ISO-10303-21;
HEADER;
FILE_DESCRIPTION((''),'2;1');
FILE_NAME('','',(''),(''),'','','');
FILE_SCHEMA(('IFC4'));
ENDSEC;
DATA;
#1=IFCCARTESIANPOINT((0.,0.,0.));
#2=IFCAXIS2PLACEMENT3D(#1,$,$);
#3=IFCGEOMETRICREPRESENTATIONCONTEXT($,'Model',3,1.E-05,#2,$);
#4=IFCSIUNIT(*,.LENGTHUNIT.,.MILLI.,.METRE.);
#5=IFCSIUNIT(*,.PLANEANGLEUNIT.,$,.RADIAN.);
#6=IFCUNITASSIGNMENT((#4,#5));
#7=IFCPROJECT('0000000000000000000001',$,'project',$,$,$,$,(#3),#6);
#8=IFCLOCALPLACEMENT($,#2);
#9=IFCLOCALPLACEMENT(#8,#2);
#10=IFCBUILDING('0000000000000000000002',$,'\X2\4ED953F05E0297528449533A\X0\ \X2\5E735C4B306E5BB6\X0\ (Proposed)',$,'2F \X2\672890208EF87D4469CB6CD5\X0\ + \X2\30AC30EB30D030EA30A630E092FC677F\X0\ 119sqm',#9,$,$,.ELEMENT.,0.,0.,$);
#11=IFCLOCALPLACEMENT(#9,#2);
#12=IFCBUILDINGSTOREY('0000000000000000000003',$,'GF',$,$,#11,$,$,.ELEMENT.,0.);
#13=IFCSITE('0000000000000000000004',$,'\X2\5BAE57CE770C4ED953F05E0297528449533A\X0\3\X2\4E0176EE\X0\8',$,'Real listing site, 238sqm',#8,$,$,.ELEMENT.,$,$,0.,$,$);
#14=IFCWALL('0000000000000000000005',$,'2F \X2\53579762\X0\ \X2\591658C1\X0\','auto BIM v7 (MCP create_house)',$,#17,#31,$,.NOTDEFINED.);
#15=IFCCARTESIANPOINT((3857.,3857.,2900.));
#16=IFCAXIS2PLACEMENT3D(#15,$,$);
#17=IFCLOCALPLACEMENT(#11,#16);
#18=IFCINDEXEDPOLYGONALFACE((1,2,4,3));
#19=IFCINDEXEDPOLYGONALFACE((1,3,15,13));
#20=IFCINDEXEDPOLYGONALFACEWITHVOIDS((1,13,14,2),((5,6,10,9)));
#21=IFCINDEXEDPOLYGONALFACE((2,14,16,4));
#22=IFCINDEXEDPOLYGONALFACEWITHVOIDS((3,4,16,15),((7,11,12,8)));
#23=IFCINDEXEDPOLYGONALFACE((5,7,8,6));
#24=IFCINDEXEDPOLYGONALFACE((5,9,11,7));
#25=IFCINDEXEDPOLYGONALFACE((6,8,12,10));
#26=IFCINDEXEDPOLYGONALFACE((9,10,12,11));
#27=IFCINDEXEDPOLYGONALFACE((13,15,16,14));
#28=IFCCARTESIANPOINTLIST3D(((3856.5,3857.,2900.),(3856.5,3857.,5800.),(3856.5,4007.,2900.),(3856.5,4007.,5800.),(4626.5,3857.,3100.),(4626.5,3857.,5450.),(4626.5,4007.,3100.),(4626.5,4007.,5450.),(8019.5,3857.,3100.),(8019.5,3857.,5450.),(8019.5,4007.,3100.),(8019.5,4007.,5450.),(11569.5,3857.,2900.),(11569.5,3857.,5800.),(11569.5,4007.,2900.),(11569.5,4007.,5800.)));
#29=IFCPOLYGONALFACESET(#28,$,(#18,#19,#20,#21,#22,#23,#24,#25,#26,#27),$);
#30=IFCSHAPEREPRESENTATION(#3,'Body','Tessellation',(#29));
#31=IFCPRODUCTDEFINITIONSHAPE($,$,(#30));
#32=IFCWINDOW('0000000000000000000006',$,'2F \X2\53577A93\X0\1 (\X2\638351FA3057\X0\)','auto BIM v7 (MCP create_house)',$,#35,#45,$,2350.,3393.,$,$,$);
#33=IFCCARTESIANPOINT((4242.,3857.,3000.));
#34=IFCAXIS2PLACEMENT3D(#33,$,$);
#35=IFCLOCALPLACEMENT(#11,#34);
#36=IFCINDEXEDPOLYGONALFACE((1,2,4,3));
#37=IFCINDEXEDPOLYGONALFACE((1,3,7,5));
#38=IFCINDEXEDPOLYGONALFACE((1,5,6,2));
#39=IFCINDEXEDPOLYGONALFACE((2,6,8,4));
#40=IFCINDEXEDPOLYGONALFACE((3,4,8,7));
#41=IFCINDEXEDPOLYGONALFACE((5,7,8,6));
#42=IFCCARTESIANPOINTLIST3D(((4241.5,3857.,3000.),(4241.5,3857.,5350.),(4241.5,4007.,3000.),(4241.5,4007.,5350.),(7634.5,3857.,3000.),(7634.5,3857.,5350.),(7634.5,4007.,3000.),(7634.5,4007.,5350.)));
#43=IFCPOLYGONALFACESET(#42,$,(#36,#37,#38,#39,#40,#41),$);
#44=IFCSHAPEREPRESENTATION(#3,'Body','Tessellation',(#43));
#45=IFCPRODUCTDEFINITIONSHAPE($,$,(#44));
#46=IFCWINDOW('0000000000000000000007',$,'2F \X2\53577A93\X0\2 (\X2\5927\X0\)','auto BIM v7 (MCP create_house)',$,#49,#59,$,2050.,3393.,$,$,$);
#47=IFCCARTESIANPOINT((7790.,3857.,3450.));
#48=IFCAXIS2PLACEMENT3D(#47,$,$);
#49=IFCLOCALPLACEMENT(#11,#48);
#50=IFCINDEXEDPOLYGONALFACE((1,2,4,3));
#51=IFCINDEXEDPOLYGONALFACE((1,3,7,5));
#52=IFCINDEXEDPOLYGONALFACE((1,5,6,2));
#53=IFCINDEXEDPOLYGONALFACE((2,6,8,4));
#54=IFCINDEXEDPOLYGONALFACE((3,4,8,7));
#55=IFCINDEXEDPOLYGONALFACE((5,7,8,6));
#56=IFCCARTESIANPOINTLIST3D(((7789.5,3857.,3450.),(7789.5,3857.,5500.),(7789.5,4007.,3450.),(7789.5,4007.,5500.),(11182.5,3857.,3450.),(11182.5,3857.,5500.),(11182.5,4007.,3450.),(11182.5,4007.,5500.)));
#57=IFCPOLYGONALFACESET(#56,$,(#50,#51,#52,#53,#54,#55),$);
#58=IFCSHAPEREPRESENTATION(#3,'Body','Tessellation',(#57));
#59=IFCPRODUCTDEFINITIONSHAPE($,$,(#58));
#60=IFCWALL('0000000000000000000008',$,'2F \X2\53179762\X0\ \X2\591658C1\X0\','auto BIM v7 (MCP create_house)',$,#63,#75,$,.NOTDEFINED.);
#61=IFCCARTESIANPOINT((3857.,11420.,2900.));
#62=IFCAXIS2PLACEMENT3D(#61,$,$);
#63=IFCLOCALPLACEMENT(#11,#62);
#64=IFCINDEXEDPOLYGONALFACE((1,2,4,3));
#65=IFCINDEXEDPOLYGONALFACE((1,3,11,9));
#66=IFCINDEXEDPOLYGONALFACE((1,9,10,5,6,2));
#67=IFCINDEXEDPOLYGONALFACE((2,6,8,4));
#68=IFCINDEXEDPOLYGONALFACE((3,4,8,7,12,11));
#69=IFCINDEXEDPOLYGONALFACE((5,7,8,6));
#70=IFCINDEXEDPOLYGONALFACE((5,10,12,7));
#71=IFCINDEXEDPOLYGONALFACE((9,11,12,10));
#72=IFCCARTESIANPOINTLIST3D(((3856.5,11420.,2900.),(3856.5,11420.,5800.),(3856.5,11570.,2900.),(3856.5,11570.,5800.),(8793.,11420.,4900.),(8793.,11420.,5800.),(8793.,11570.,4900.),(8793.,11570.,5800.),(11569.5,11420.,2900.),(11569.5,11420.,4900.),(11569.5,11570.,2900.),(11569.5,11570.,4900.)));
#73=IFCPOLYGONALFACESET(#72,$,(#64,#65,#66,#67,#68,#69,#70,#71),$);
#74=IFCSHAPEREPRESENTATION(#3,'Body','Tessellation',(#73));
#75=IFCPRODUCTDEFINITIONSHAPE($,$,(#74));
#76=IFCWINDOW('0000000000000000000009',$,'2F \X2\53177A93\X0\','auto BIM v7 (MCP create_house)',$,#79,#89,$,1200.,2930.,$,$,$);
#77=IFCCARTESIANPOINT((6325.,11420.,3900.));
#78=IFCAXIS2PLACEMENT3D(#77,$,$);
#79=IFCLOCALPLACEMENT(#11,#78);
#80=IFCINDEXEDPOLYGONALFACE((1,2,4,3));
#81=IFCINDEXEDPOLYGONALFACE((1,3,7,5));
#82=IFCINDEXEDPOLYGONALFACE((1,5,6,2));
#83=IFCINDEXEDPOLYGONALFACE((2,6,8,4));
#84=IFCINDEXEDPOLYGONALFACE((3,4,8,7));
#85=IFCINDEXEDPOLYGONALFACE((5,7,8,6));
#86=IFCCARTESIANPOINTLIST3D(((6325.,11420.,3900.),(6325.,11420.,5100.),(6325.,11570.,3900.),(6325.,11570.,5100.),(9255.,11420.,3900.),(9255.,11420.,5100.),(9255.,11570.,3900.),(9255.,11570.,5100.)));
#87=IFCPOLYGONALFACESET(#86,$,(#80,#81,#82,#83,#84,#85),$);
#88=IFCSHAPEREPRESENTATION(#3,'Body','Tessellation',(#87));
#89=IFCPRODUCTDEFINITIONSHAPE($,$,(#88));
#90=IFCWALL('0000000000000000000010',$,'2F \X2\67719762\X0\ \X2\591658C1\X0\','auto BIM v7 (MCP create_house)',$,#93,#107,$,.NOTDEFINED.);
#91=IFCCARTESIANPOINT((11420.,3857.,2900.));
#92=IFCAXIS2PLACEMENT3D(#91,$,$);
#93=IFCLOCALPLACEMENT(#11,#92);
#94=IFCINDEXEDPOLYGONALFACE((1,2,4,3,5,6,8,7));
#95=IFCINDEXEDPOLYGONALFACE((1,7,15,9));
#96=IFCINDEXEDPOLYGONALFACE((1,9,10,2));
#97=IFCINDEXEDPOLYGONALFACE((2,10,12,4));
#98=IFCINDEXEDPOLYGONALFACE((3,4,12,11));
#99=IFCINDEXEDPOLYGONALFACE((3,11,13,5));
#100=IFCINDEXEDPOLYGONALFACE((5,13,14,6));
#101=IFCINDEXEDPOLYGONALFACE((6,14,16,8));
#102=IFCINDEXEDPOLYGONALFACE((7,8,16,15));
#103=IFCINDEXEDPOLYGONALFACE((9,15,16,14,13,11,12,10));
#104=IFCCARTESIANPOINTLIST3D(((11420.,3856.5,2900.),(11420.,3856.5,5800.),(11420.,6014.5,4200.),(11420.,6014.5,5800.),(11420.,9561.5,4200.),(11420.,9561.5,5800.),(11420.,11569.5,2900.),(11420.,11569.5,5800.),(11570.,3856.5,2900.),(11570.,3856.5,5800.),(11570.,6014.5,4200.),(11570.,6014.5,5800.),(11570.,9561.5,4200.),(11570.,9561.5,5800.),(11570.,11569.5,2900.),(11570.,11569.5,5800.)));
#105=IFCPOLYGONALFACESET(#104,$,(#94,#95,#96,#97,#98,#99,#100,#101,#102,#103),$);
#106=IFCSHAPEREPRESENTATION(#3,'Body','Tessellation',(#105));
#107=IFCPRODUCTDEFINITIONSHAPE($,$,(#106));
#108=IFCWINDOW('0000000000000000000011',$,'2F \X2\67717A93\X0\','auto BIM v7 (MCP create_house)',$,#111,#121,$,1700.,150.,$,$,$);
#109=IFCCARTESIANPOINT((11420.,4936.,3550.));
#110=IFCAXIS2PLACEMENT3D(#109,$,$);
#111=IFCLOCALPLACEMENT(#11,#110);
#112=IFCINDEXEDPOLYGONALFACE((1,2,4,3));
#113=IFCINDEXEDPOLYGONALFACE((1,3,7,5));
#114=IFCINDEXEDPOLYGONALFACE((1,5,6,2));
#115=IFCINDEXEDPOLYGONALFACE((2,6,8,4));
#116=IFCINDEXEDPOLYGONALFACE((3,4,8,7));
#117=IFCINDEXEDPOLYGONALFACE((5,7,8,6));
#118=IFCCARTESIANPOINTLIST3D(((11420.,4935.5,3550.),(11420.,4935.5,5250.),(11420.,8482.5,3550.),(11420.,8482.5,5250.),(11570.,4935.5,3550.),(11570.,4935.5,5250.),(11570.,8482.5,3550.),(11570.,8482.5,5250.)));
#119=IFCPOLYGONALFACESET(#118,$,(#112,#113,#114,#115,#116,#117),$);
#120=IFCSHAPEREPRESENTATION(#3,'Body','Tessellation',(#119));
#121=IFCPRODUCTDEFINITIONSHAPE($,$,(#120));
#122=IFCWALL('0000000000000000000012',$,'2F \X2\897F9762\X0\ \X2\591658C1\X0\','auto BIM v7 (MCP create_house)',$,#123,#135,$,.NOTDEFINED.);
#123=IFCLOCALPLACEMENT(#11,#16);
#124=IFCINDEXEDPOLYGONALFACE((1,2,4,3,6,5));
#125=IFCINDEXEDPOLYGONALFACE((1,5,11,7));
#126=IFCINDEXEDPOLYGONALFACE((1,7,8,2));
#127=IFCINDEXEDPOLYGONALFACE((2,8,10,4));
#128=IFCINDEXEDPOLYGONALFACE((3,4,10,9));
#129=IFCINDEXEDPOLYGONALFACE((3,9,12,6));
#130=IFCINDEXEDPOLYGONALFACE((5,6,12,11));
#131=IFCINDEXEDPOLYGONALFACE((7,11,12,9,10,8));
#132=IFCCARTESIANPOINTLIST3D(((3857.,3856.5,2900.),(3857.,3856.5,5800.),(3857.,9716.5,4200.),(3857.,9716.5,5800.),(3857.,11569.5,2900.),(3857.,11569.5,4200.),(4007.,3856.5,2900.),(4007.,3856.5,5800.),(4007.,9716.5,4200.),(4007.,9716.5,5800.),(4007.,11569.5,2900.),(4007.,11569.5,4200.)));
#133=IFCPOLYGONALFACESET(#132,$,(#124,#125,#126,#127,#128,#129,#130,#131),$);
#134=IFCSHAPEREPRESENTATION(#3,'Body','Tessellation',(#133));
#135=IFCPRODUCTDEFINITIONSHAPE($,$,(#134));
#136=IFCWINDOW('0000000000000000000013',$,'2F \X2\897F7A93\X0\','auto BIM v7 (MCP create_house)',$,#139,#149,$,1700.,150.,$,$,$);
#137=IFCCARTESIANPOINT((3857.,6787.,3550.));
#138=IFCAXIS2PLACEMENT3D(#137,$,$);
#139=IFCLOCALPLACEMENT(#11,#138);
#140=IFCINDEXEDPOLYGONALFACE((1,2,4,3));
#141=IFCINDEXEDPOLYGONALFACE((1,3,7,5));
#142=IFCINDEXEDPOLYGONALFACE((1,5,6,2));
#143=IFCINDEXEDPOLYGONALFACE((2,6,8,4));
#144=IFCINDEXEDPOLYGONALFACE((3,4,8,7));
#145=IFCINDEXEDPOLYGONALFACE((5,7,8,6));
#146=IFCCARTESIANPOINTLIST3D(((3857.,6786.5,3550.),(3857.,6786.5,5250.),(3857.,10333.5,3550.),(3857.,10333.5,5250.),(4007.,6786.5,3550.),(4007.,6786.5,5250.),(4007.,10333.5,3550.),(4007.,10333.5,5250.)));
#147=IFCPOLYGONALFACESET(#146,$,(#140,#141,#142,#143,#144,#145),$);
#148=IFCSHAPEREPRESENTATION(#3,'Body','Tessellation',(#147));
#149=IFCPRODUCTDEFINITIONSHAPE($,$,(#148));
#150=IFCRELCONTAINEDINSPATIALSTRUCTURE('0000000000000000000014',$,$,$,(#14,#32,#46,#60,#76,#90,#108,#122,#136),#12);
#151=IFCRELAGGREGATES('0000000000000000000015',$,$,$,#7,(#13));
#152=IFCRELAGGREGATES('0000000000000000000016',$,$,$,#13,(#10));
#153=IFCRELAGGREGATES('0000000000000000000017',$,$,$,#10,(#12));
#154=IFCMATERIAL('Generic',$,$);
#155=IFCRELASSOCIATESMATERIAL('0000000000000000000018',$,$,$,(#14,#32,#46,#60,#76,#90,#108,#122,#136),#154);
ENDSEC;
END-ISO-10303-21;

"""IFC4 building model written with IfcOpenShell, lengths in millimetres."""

from ifc_helpers import new_model, si_unit, frame, frame_2d, origin, place, context, project, spatial, rectangle, extrude, material, element, fill, save


model = new_model("IFC4")

# Units and contexts
model_context = context("Model", 3, precision=1e-05, world=origin())
ifc_project = project(units=[si_unit("LENGTHUNIT", "METRE", prefix="MILLI"), si_unit("PLANEANGLEUNIT", "RADIAN")], contexts=[model_context])

# Site, building, storey
site_placement = place(None, origin())
site = spatial("IfcSite", under=ifc_project, at=site_placement, Name="宮城県仙台市青葉区3丁目8", ObjectType="Real listing site, 238sqm", CompositionType="ELEMENT", RefElevation=0.0)
building_placement = place(site_placement, origin())
building = spatial("IfcBuilding", under=site, at=building_placement, Name="仙台市青葉区 平屋の家 (Proposed)", ObjectType="2F 木造軸組構法 + ガルバリウム鋼板 119sqm", CompositionType="ELEMENT", ElevationOfRefHeight=0.0, ElevationOfTerrain=0.0)
storey_placement = place(building_placement, origin())
storey = spatial("IfcBuildingStorey", under=building, at=storey_placement, Name="GF", CompositionType="ELEMENT", Elevation=0.0)

# Shared definitions
ifc_material = material(Name="Generic")

# Wall, openings, windows
wall_1_placement = place(storey_placement, frame((3857.0, 3857.0, 2900.0)))
wall_1 = element("IfcWall", 1, at=wall_1_placement, inside=storey, material=ifc_material, Name="2F 南面 外壁", Description="auto BIM v7 (MCP create_house)", PredefinedType="NOTDEFINED", context=model_context, shape_type="SweptSolid", body=[
    extrude(rectangle(XDim=7713.0, YDim=150.0, at=frame_2d((3856.0, 75.0))), frame((3857.0, 3857.0, 2900.0)), (0.0, 0.0, 1.0), 2900.0),
])
opening_1_placement = place(storey_placement, frame((4242.0, 3857.0, 3000.0)))
opening_1 = element("IfcOpeningElement", 2, at=opening_1_placement, cuts=wall_1, PredefinedType="NOTDEFINED", context=model_context, shape_type="SweptSolid", body=[
    extrude(rectangle(XDim=3393.0, YDim=150.0, at=frame_2d((1696.0, 75.0))), frame((4242.0, 3857.0, 3000.0)), (0.0, 0.0, 1.0), 2350.0),
])
opening_2_placement = place(storey_placement, frame((7790.0, 3857.0, 3450.0)))
opening_2 = element("IfcOpeningElement", 3, at=opening_2_placement, cuts=wall_1, PredefinedType="NOTDEFINED", context=model_context, shape_type="SweptSolid", body=[
    extrude(rectangle(XDim=3393.0, YDim=150.0, at=frame_2d((1696.0, 75.0))), frame((7790.0, 3857.0, 3450.0)), (0.0, 0.0, 1.0), 2050.0),
])
window_1_placement = place(storey_placement, frame((4242.0, 3857.0, 3000.0)))
window_1 = element("IfcWindow", 4, at=window_1_placement, inside=storey, material=ifc_material, Name="2F 南窓1 (掃出し)", Description="auto BIM v7 (MCP create_house)", OverallHeight=2350.0, OverallWidth=3393.0, context=model_context, shape_type="SweptSolid", body=[
    extrude(rectangle(XDim=3393.0, YDim=150.0, at=frame_2d((1696.0, 75.0))), frame((4242.0, 3857.0, 3000.0)), (0.0, 0.0, 1.0), 2350.0),
])
fill(opening_1, window_1)
window_2_placement = place(storey_placement, frame((7790.0, 3857.0, 3450.0)))
window_2 = element("IfcWindow", 5, at=window_2_placement, inside=storey, material=ifc_material, Name="2F 南窓2 (大)", Description="auto BIM v7 (MCP create_house)", OverallHeight=2050.0, OverallWidth=3393.0, context=model_context, shape_type="SweptSolid", body=[
    extrude(rectangle(XDim=3393.0, YDim=150.0, at=frame_2d((1696.0, 75.0))), frame((7790.0, 3857.0, 3450.0)), (0.0, 0.0, 1.0), 2050.0),
])
fill(opening_2, window_2)

# Walls, openings, windows
wall_2_placement = place(storey_placement, frame((3857.0, 11420.0, 2900.0)))
wall_2 = element("IfcWall", 6, at=wall_2_placement, inside=storey, material=ifc_material, Name="2F 北面 外壁", Description="auto BIM v7 (MCP create_house)", PredefinedType="NOTDEFINED", context=model_context, shape_type="SweptSolid", body=[
    extrude(rectangle(XDim=7713.0, YDim=150.0, at=frame_2d((3856.0, 75.0))), frame((3857.0, 11420.0, 2900.0)), (0.0, 0.0, 1.0), 2900.0),
])
opening_3_placement = place(storey_placement, frame((6325.0, 11420.0, 3900.0)))
opening_3 = element("IfcOpeningElement", 7, at=opening_3_placement, cuts=wall_2, PredefinedType="NOTDEFINED", context=model_context, shape_type="SweptSolid", body=[
    extrude(rectangle(XDim=2930.0, YDim=150.0, at=frame_2d((1465.0, 75.0))), frame((6325.0, 11420.0, 3900.0)), (0.0, 0.0, 1.0), 1200.0),
])
window_3_placement = place(storey_placement, frame((6325.0, 11420.0, 3900.0)))
window_3 = element("IfcWindow", 8, at=window_3_placement, inside=storey, material=ifc_material, Name="2F 北窓", Description="auto BIM v7 (MCP create_house)", OverallHeight=1200.0, OverallWidth=2930.0, context=model_context, shape_type="SweptSolid", body=[
    extrude(rectangle(XDim=2930.0, YDim=150.0, at=frame_2d((1465.0, 75.0))), frame((6325.0, 11420.0, 3900.0)), (0.0, 0.0, 1.0), 1200.0),
])
fill(opening_3, window_3)
wall_3_placement = place(storey_placement, frame((11420.0, 3857.0, 2900.0)))
wall_3 = element("IfcWall", 9, at=wall_3_placement, inside=storey, material=ifc_material, Name="2F 東面 外壁", Description="auto BIM v7 (MCP create_house)", PredefinedType="NOTDEFINED", context=model_context, shape_type="SweptSolid", body=[
    extrude(rectangle(XDim=150.0, YDim=7713.0, at=frame_2d((75.0, 3856.0))), frame((11420.0, 3857.0, 2900.0)), (0.0, 0.0, 1.0), 2900.0),
])
opening_4_placement = place(storey_placement, frame((11420.0, 4936.0, 3550.0)))
opening_4 = element("IfcOpeningElement", 10, at=opening_4_placement, cuts=wall_3, PredefinedType="NOTDEFINED", context=model_context, shape_type="SweptSolid", body=[
    extrude(rectangle(XDim=150.0, YDim=3547.0, at=frame_2d((75.0, 1773.0))), frame((11420.0, 4936.0, 3550.0)), (0.0, 0.0, 1.0), 1700.0),
])
window_4_placement = place(storey_placement, frame((11420.0, 4936.0, 3550.0)))
window_4 = element("IfcWindow", 11, at=window_4_placement, inside=storey, material=ifc_material, Name="2F 東窓", Description="auto BIM v7 (MCP create_house)", OverallHeight=1700.0, OverallWidth=150.0, context=model_context, shape_type="SweptSolid", body=[
    extrude(rectangle(XDim=150.0, YDim=3547.0, at=frame_2d((75.0, 1773.0))), frame((11420.0, 4936.0, 3550.0)), (0.0, 0.0, 1.0), 1700.0),
])
fill(opening_4, window_4)
wall_4_placement = place(storey_placement, frame((3857.0, 3857.0, 2900.0)))
wall_4 = element("IfcWall", 12, at=wall_4_placement, inside=storey, material=ifc_material, Name="2F 西面 外壁", Description="auto BIM v7 (MCP create_house)", PredefinedType="NOTDEFINED", context=model_context, shape_type="SweptSolid", body=[
    extrude(rectangle(XDim=150.0, YDim=7713.0, at=frame_2d((75.0, 3856.0))), frame((3857.0, 3857.0, 2900.0)), (0.0, 0.0, 1.0), 2900.0),
])
opening_5_placement = place(storey_placement, frame((3857.0, 6787.0, 3550.0)))
opening_5 = element("IfcOpeningElement", 13, at=opening_5_placement, cuts=wall_4, PredefinedType="NOTDEFINED", context=model_context, shape_type="SweptSolid", body=[
    extrude(rectangle(XDim=150.0, YDim=3547.0, at=frame_2d((75.0, 1773.0))), frame((3857.0, 6787.0, 3550.0)), (0.0, 0.0, 1.0), 1700.0),
])
window_5_placement = place(storey_placement, frame((3857.0, 6787.0, 3550.0)))
window_5 = element("IfcWindow", 14, at=window_5_placement, inside=storey, material=ifc_material, Name="2F 西窓", Description="auto BIM v7 (MCP create_house)", OverallHeight=1700.0, OverallWidth=150.0, context=model_context, shape_type="SweptSolid", body=[
    extrude(rectangle(XDim=150.0, YDim=3547.0, at=frame_2d((75.0, 1773.0))), frame((3857.0, 6787.0, 3550.0)), (0.0, 0.0, 1.0), 1700.0),
])
fill(opening_5, window_5)

save(model, "model.ifc")
